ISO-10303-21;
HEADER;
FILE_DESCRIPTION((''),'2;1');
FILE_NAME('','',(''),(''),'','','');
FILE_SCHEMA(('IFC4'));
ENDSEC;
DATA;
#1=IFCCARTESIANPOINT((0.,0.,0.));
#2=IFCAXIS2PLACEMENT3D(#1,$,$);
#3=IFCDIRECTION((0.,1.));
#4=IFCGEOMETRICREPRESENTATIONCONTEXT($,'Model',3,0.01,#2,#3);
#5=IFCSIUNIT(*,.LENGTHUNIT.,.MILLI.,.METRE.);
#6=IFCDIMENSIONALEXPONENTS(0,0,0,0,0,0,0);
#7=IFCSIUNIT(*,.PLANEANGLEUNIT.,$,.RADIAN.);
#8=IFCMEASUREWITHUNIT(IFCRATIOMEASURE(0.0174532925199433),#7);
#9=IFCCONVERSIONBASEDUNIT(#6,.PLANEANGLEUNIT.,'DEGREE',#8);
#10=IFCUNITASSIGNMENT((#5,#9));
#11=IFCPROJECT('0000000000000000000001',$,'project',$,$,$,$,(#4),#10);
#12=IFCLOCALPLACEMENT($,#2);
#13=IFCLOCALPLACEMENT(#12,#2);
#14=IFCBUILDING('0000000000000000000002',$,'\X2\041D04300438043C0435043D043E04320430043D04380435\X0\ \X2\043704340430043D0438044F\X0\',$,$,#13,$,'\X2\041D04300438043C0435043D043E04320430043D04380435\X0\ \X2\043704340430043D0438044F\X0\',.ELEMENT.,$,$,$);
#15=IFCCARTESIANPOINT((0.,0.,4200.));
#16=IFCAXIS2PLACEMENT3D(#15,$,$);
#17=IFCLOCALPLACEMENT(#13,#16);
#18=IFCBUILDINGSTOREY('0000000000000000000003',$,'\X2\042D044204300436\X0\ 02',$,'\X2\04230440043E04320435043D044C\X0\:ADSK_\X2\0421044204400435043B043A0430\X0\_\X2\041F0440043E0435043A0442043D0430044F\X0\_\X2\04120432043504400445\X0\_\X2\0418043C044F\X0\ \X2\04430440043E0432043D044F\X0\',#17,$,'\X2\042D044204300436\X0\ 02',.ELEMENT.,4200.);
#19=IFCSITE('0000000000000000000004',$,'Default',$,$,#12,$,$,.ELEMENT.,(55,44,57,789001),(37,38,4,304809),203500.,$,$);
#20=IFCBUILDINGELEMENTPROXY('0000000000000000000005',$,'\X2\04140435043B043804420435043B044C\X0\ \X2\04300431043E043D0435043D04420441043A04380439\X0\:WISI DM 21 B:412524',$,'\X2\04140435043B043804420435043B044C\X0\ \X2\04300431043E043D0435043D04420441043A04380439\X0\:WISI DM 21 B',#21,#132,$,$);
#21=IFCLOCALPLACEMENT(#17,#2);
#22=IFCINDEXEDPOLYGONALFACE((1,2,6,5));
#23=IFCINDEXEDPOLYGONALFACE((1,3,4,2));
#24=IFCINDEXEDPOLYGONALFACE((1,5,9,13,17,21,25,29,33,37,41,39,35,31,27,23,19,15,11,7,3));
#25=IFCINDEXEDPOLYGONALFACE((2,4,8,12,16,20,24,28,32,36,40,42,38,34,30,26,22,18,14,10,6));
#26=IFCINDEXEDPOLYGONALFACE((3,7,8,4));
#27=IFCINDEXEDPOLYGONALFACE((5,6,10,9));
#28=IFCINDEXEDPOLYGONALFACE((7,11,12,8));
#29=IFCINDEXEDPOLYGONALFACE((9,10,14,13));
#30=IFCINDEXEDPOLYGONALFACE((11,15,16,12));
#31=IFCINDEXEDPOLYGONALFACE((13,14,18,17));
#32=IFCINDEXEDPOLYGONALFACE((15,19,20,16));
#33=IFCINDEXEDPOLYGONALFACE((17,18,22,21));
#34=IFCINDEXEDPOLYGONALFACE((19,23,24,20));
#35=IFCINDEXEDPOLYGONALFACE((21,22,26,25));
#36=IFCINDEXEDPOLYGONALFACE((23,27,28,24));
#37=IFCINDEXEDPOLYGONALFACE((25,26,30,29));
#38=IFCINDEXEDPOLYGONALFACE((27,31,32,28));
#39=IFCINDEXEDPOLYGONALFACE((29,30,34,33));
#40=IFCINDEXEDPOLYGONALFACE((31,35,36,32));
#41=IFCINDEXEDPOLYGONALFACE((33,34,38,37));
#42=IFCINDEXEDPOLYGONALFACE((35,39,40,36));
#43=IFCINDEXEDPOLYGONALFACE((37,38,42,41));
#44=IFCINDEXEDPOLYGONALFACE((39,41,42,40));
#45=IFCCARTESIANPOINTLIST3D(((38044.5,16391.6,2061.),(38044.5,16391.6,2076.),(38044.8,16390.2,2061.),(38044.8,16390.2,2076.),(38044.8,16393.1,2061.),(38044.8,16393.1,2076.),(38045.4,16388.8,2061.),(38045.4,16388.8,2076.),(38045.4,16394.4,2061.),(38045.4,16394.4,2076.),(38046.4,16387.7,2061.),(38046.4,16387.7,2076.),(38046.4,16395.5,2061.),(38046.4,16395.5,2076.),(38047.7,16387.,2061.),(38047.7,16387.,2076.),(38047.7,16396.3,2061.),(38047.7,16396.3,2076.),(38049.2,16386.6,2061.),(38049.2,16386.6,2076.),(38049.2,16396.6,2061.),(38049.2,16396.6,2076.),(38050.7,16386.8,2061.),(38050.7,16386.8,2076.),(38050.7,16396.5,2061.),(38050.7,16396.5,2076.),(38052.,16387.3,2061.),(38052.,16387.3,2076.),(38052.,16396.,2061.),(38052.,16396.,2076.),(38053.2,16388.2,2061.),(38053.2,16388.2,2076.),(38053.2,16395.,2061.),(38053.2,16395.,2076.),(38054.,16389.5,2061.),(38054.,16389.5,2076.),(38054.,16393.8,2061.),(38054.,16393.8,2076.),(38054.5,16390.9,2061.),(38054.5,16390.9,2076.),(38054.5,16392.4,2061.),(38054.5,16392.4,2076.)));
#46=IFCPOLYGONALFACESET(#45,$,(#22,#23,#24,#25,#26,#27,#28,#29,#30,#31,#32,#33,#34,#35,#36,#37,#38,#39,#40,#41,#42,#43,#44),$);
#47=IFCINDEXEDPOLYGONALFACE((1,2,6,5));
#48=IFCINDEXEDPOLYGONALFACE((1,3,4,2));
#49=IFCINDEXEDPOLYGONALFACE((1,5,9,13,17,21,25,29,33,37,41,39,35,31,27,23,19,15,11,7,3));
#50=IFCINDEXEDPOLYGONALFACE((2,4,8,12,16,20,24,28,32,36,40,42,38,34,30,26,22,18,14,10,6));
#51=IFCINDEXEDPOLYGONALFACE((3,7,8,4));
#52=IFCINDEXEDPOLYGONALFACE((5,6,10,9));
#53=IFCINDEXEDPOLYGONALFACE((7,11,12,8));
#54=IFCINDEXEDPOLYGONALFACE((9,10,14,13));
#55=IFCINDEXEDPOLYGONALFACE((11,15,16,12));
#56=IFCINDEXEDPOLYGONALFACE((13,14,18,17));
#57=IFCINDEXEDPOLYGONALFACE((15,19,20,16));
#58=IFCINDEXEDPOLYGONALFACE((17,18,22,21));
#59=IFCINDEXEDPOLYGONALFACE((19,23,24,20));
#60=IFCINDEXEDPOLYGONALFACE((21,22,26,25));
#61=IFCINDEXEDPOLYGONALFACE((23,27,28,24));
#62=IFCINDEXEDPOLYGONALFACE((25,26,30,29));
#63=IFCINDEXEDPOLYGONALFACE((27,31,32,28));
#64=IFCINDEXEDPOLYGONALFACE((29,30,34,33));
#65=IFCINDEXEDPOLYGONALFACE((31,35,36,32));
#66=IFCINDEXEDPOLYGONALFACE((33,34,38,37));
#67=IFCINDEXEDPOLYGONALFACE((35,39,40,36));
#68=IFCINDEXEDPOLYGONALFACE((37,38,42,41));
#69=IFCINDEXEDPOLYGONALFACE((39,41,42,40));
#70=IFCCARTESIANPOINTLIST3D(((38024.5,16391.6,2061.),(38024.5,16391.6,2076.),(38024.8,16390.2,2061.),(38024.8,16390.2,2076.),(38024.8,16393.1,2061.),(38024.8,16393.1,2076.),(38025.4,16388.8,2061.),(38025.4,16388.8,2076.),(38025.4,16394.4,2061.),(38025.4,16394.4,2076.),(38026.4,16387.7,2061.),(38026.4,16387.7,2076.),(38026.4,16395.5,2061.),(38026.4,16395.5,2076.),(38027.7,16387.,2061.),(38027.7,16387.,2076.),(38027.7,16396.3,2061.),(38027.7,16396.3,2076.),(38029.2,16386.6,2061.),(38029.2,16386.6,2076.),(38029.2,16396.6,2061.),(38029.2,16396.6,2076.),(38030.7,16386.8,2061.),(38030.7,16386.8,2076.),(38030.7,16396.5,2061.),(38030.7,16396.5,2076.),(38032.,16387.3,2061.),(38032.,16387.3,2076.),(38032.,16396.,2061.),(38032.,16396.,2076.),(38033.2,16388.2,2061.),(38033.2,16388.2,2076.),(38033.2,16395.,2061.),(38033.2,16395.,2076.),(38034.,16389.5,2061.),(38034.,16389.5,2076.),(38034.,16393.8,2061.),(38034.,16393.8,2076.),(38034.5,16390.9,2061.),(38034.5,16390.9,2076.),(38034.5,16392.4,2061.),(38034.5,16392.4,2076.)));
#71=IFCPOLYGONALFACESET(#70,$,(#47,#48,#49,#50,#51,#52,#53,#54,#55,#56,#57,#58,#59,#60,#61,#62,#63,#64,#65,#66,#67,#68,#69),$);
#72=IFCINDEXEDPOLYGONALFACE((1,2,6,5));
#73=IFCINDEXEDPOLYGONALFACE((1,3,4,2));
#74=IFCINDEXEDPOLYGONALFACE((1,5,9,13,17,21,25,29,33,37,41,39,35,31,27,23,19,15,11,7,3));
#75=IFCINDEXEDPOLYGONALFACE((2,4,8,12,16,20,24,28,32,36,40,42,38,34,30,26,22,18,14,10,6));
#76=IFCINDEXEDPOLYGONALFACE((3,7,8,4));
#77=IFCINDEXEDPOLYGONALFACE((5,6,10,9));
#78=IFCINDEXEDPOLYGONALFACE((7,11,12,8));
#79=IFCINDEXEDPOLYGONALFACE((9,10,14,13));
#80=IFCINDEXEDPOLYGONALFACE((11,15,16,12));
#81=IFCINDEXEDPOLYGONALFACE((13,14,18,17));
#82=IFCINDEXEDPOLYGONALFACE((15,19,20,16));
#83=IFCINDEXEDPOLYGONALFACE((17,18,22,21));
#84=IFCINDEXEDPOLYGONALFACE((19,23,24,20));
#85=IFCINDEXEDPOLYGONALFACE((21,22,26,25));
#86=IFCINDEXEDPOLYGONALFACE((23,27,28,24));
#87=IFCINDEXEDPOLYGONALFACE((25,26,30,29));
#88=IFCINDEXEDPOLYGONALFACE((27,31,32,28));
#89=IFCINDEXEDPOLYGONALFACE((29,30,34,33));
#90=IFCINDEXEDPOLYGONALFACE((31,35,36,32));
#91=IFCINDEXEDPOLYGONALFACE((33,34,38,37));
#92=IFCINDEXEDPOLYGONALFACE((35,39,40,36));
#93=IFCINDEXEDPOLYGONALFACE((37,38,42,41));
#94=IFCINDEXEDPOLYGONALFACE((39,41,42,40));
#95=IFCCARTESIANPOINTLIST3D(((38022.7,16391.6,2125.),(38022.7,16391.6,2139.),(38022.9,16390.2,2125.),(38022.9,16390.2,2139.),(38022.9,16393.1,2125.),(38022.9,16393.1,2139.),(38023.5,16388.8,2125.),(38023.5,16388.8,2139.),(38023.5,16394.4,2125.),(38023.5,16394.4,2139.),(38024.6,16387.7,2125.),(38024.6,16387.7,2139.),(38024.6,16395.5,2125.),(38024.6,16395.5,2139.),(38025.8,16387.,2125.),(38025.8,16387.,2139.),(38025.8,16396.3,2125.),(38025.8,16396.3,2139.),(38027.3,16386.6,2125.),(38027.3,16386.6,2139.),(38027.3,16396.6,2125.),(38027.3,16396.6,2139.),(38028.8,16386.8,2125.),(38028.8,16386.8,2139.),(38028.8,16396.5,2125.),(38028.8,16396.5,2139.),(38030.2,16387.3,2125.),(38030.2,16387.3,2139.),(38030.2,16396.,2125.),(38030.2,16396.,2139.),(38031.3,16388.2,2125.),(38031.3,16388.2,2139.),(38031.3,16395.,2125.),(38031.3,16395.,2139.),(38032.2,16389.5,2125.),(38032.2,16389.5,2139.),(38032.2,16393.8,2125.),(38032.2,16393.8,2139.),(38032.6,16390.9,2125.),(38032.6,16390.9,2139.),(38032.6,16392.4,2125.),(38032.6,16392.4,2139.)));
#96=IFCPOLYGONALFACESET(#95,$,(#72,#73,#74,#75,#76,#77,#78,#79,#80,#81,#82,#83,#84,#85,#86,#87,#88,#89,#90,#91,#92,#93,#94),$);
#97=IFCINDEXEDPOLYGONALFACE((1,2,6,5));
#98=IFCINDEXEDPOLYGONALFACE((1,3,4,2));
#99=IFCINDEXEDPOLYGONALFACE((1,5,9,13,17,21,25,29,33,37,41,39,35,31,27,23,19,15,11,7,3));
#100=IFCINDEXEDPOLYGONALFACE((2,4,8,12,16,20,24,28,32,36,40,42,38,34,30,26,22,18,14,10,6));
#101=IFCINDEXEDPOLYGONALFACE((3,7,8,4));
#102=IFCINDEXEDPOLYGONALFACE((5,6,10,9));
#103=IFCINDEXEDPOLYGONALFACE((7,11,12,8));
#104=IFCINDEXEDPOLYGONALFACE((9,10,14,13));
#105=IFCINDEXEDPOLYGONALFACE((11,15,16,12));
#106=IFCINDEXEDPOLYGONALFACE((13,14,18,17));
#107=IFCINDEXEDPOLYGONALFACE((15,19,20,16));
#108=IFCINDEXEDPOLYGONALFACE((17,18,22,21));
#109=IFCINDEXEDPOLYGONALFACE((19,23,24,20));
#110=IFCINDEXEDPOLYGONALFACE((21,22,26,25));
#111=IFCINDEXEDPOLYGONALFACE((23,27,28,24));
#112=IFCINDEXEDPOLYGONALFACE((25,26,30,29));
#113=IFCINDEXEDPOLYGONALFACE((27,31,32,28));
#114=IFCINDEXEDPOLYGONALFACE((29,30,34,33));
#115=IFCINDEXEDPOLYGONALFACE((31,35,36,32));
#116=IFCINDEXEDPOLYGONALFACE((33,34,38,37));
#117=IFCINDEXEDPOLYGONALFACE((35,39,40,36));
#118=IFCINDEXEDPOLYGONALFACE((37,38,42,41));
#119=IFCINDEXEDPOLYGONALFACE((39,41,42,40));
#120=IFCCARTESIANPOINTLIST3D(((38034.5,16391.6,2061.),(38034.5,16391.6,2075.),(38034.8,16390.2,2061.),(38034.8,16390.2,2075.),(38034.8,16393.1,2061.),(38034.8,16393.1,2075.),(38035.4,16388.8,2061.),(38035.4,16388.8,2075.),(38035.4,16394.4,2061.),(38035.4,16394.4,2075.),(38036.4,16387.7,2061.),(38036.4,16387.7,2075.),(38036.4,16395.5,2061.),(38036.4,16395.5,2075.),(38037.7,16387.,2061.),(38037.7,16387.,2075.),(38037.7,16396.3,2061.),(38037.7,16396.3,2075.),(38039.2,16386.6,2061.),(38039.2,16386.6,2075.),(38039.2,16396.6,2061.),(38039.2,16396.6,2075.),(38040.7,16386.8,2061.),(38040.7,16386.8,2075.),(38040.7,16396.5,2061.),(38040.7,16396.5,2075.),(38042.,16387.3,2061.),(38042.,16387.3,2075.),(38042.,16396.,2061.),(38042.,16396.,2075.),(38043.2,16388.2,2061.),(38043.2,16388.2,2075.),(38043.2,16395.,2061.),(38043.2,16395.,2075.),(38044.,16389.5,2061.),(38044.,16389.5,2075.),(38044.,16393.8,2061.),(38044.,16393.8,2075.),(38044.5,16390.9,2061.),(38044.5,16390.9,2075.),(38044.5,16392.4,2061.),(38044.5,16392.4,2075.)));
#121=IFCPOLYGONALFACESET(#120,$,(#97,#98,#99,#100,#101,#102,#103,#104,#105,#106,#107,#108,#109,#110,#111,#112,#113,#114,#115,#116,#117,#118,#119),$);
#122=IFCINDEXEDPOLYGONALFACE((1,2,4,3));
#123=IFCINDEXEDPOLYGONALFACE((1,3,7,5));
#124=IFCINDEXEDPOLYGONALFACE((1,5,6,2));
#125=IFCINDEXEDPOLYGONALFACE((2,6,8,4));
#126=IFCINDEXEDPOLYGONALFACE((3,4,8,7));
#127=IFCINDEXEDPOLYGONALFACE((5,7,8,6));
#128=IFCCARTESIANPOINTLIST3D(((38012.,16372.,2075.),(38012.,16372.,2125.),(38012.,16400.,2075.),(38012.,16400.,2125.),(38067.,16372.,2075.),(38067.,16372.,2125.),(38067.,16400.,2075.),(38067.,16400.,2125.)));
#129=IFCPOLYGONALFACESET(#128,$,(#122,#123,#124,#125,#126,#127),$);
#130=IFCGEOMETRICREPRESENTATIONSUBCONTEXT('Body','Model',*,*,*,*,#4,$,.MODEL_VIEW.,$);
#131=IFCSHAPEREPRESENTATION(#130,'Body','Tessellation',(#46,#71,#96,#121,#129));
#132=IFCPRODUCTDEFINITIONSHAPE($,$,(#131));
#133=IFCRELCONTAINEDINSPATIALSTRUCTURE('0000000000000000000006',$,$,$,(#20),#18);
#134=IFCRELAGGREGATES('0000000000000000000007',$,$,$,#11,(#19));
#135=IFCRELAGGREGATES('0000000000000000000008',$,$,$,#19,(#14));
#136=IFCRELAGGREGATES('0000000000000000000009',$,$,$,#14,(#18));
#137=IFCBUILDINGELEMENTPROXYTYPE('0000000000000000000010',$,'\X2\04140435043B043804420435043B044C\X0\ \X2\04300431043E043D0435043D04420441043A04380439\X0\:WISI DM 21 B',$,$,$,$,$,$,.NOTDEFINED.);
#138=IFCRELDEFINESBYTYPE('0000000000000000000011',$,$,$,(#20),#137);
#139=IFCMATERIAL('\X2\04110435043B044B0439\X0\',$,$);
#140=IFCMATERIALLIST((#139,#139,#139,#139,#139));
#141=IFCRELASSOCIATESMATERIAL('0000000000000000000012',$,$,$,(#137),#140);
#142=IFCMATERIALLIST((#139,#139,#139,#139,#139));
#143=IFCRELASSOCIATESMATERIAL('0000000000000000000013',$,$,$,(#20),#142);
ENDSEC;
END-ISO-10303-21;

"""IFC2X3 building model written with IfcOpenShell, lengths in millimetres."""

from ifc_helpers import new_model, entity, si_unit, converted_unit, direction, frame, frame_2d, origin, place, context, subcontext, project, spatial, rectangle, circle, extrude, source, transform, mapped, material, material_list, type_object, type_shapes, element, save


model = new_model("IFC2X3")

# Units and contexts
model_context = context("Model", 3, precision=0.01, world=origin(), true_north=direction((0.0, 1.0)))
body_context = subcontext(model_context, "Body", "Model", "MODEL_VIEW")
ifc_project = project(units=[si_unit("LENGTHUNIT", "METRE", prefix="MILLI"), converted_unit("PLANEANGLEUNIT", "DEGREE", entity("IfcRatioMeasure", 0.0174532925199433), si_unit("PLANEANGLEUNIT", "RADIAN"), dimensions=[0, 0, 0, 0, 0, 0, 0])], contexts=[model_context])

# Site, building, storey
site_placement = place(None, frame((0.0, 0.0, 0.0)))
site = spatial("IfcSite", under=ifc_project, at=site_placement, Name="Default", CompositionType="ELEMENT", RefLatitude=(55, 44, 57, 789001), RefLongitude=(37, 38, 4, 304809), RefElevation=203500.0)
building_placement = place(site_placement, origin())
building = spatial("IfcBuilding", under=site, at=building_placement, Name="Наименование здания", LongName="Наименование здания", CompositionType="ELEMENT")
storey_placement = place(building_placement, frame((0.0, 0.0, 4200.0)))
storey = spatial("IfcBuildingStorey", under=building, at=storey_placement, Name="Этаж 02", ObjectType="Уровень:ADSK_Стрелка_Проектная_Вверх_Имя уровня", LongName="Этаж 02", CompositionType="ELEMENT", Elevation=4200.0)

# Building element proxy
ifc_material_1 = material(Name="Белый")
ifc_material_list_1 = material_list([ifc_material_1, ifc_material_1, ifc_material_1, ifc_material_1, ifc_material_1])
ifc_material_list_2 = material_list([ifc_material_1, ifc_material_1, ifc_material_1, ifc_material_1, ifc_material_1])
building_element_proxy_type_1 = type_object("IfcBuildingElementProxyType", Name="Делитель абонентский:WISI DM 21 B", PredefinedType="NOTDEFINED", material=ifc_material_list_2)
shared_shape_1 = source(origin(), body_context, "Body", "SweptSolid", [
    extrude(circle(Radius=5.0, at=frame_2d((0.0, 0.0), x_axis=(1.0, 0.0))), frame((10.0, -39.0, 8.4), z_axis=(0.0, 1.0, 0.0), x_axis=(-1.0, 0.0, 0.0)), (0.0, 0.0, 1.0), 15.0),
    extrude(circle(Radius=5.0, at=frame_2d((0.0, 0.0), x_axis=(1.0, 0.0))), frame((-10.0, -39.0, 8.4), z_axis=(0.0, 1.0, 0.0), x_axis=(-1.0, 0.0, 0.0)), (0.0, 0.0, 1.0), 15.0),
    extrude(circle(Radius=5.0, at=frame_2d((0.0, 0.0), x_axis=(1.0, 0.0))), frame((-11.8, 25.0, 8.4), z_axis=(0.0, 1.0, 0.0), x_axis=(-1.0, 0.0, 0.0)), (0.0, 0.0, 1.0), 14.0),
    extrude(circle(Radius=5.0, at=frame_2d((0.0, 0.0), x_axis=(1.0, 0.0))), frame((0.0, -39.0, 8.4), z_axis=(0.0, 1.0, 0.0), x_axis=(-1.0, 0.0, 0.0)), (0.0, 0.0, 1.0), 14.0),
    extrude(rectangle(XDim=55.0, YDim=50.0, at=frame_2d((0.0, 0.0), x_axis=(1.0, 0.0))), frame((0.0, 0.0, 0.0), z_axis=(0.0, 0.0, 1.0), x_axis=(-1.0, 0.0, 0.0)), (0.0, 0.0, 1.0), 28.0),
])
type_shapes(building_element_proxy_type_1, [shared_shape_1])
proxy_1_placement = place(storey_placement, frame((38039.5, 16400.0, 2100.0), z_axis=(0.0, -1.0, 0.0), x_axis=(1.0, 0.0, 0.0)))
element("IfcBuildingElementProxy", 1, at=proxy_1_placement, inside=storey, type_object=building_element_proxy_type_1, material=ifc_material_list_1, Name="Делитель абонентский:WISI DM 21 B:412524", ObjectType="Делитель абонентский:WISI DM 21 B", context=body_context, shape_type="MappedRepresentation", body=[
    mapped(shared_shape_1, transform((0.0, 0.0, 0.0), scale=1.0)),
])

save(model, "model.ifc")
